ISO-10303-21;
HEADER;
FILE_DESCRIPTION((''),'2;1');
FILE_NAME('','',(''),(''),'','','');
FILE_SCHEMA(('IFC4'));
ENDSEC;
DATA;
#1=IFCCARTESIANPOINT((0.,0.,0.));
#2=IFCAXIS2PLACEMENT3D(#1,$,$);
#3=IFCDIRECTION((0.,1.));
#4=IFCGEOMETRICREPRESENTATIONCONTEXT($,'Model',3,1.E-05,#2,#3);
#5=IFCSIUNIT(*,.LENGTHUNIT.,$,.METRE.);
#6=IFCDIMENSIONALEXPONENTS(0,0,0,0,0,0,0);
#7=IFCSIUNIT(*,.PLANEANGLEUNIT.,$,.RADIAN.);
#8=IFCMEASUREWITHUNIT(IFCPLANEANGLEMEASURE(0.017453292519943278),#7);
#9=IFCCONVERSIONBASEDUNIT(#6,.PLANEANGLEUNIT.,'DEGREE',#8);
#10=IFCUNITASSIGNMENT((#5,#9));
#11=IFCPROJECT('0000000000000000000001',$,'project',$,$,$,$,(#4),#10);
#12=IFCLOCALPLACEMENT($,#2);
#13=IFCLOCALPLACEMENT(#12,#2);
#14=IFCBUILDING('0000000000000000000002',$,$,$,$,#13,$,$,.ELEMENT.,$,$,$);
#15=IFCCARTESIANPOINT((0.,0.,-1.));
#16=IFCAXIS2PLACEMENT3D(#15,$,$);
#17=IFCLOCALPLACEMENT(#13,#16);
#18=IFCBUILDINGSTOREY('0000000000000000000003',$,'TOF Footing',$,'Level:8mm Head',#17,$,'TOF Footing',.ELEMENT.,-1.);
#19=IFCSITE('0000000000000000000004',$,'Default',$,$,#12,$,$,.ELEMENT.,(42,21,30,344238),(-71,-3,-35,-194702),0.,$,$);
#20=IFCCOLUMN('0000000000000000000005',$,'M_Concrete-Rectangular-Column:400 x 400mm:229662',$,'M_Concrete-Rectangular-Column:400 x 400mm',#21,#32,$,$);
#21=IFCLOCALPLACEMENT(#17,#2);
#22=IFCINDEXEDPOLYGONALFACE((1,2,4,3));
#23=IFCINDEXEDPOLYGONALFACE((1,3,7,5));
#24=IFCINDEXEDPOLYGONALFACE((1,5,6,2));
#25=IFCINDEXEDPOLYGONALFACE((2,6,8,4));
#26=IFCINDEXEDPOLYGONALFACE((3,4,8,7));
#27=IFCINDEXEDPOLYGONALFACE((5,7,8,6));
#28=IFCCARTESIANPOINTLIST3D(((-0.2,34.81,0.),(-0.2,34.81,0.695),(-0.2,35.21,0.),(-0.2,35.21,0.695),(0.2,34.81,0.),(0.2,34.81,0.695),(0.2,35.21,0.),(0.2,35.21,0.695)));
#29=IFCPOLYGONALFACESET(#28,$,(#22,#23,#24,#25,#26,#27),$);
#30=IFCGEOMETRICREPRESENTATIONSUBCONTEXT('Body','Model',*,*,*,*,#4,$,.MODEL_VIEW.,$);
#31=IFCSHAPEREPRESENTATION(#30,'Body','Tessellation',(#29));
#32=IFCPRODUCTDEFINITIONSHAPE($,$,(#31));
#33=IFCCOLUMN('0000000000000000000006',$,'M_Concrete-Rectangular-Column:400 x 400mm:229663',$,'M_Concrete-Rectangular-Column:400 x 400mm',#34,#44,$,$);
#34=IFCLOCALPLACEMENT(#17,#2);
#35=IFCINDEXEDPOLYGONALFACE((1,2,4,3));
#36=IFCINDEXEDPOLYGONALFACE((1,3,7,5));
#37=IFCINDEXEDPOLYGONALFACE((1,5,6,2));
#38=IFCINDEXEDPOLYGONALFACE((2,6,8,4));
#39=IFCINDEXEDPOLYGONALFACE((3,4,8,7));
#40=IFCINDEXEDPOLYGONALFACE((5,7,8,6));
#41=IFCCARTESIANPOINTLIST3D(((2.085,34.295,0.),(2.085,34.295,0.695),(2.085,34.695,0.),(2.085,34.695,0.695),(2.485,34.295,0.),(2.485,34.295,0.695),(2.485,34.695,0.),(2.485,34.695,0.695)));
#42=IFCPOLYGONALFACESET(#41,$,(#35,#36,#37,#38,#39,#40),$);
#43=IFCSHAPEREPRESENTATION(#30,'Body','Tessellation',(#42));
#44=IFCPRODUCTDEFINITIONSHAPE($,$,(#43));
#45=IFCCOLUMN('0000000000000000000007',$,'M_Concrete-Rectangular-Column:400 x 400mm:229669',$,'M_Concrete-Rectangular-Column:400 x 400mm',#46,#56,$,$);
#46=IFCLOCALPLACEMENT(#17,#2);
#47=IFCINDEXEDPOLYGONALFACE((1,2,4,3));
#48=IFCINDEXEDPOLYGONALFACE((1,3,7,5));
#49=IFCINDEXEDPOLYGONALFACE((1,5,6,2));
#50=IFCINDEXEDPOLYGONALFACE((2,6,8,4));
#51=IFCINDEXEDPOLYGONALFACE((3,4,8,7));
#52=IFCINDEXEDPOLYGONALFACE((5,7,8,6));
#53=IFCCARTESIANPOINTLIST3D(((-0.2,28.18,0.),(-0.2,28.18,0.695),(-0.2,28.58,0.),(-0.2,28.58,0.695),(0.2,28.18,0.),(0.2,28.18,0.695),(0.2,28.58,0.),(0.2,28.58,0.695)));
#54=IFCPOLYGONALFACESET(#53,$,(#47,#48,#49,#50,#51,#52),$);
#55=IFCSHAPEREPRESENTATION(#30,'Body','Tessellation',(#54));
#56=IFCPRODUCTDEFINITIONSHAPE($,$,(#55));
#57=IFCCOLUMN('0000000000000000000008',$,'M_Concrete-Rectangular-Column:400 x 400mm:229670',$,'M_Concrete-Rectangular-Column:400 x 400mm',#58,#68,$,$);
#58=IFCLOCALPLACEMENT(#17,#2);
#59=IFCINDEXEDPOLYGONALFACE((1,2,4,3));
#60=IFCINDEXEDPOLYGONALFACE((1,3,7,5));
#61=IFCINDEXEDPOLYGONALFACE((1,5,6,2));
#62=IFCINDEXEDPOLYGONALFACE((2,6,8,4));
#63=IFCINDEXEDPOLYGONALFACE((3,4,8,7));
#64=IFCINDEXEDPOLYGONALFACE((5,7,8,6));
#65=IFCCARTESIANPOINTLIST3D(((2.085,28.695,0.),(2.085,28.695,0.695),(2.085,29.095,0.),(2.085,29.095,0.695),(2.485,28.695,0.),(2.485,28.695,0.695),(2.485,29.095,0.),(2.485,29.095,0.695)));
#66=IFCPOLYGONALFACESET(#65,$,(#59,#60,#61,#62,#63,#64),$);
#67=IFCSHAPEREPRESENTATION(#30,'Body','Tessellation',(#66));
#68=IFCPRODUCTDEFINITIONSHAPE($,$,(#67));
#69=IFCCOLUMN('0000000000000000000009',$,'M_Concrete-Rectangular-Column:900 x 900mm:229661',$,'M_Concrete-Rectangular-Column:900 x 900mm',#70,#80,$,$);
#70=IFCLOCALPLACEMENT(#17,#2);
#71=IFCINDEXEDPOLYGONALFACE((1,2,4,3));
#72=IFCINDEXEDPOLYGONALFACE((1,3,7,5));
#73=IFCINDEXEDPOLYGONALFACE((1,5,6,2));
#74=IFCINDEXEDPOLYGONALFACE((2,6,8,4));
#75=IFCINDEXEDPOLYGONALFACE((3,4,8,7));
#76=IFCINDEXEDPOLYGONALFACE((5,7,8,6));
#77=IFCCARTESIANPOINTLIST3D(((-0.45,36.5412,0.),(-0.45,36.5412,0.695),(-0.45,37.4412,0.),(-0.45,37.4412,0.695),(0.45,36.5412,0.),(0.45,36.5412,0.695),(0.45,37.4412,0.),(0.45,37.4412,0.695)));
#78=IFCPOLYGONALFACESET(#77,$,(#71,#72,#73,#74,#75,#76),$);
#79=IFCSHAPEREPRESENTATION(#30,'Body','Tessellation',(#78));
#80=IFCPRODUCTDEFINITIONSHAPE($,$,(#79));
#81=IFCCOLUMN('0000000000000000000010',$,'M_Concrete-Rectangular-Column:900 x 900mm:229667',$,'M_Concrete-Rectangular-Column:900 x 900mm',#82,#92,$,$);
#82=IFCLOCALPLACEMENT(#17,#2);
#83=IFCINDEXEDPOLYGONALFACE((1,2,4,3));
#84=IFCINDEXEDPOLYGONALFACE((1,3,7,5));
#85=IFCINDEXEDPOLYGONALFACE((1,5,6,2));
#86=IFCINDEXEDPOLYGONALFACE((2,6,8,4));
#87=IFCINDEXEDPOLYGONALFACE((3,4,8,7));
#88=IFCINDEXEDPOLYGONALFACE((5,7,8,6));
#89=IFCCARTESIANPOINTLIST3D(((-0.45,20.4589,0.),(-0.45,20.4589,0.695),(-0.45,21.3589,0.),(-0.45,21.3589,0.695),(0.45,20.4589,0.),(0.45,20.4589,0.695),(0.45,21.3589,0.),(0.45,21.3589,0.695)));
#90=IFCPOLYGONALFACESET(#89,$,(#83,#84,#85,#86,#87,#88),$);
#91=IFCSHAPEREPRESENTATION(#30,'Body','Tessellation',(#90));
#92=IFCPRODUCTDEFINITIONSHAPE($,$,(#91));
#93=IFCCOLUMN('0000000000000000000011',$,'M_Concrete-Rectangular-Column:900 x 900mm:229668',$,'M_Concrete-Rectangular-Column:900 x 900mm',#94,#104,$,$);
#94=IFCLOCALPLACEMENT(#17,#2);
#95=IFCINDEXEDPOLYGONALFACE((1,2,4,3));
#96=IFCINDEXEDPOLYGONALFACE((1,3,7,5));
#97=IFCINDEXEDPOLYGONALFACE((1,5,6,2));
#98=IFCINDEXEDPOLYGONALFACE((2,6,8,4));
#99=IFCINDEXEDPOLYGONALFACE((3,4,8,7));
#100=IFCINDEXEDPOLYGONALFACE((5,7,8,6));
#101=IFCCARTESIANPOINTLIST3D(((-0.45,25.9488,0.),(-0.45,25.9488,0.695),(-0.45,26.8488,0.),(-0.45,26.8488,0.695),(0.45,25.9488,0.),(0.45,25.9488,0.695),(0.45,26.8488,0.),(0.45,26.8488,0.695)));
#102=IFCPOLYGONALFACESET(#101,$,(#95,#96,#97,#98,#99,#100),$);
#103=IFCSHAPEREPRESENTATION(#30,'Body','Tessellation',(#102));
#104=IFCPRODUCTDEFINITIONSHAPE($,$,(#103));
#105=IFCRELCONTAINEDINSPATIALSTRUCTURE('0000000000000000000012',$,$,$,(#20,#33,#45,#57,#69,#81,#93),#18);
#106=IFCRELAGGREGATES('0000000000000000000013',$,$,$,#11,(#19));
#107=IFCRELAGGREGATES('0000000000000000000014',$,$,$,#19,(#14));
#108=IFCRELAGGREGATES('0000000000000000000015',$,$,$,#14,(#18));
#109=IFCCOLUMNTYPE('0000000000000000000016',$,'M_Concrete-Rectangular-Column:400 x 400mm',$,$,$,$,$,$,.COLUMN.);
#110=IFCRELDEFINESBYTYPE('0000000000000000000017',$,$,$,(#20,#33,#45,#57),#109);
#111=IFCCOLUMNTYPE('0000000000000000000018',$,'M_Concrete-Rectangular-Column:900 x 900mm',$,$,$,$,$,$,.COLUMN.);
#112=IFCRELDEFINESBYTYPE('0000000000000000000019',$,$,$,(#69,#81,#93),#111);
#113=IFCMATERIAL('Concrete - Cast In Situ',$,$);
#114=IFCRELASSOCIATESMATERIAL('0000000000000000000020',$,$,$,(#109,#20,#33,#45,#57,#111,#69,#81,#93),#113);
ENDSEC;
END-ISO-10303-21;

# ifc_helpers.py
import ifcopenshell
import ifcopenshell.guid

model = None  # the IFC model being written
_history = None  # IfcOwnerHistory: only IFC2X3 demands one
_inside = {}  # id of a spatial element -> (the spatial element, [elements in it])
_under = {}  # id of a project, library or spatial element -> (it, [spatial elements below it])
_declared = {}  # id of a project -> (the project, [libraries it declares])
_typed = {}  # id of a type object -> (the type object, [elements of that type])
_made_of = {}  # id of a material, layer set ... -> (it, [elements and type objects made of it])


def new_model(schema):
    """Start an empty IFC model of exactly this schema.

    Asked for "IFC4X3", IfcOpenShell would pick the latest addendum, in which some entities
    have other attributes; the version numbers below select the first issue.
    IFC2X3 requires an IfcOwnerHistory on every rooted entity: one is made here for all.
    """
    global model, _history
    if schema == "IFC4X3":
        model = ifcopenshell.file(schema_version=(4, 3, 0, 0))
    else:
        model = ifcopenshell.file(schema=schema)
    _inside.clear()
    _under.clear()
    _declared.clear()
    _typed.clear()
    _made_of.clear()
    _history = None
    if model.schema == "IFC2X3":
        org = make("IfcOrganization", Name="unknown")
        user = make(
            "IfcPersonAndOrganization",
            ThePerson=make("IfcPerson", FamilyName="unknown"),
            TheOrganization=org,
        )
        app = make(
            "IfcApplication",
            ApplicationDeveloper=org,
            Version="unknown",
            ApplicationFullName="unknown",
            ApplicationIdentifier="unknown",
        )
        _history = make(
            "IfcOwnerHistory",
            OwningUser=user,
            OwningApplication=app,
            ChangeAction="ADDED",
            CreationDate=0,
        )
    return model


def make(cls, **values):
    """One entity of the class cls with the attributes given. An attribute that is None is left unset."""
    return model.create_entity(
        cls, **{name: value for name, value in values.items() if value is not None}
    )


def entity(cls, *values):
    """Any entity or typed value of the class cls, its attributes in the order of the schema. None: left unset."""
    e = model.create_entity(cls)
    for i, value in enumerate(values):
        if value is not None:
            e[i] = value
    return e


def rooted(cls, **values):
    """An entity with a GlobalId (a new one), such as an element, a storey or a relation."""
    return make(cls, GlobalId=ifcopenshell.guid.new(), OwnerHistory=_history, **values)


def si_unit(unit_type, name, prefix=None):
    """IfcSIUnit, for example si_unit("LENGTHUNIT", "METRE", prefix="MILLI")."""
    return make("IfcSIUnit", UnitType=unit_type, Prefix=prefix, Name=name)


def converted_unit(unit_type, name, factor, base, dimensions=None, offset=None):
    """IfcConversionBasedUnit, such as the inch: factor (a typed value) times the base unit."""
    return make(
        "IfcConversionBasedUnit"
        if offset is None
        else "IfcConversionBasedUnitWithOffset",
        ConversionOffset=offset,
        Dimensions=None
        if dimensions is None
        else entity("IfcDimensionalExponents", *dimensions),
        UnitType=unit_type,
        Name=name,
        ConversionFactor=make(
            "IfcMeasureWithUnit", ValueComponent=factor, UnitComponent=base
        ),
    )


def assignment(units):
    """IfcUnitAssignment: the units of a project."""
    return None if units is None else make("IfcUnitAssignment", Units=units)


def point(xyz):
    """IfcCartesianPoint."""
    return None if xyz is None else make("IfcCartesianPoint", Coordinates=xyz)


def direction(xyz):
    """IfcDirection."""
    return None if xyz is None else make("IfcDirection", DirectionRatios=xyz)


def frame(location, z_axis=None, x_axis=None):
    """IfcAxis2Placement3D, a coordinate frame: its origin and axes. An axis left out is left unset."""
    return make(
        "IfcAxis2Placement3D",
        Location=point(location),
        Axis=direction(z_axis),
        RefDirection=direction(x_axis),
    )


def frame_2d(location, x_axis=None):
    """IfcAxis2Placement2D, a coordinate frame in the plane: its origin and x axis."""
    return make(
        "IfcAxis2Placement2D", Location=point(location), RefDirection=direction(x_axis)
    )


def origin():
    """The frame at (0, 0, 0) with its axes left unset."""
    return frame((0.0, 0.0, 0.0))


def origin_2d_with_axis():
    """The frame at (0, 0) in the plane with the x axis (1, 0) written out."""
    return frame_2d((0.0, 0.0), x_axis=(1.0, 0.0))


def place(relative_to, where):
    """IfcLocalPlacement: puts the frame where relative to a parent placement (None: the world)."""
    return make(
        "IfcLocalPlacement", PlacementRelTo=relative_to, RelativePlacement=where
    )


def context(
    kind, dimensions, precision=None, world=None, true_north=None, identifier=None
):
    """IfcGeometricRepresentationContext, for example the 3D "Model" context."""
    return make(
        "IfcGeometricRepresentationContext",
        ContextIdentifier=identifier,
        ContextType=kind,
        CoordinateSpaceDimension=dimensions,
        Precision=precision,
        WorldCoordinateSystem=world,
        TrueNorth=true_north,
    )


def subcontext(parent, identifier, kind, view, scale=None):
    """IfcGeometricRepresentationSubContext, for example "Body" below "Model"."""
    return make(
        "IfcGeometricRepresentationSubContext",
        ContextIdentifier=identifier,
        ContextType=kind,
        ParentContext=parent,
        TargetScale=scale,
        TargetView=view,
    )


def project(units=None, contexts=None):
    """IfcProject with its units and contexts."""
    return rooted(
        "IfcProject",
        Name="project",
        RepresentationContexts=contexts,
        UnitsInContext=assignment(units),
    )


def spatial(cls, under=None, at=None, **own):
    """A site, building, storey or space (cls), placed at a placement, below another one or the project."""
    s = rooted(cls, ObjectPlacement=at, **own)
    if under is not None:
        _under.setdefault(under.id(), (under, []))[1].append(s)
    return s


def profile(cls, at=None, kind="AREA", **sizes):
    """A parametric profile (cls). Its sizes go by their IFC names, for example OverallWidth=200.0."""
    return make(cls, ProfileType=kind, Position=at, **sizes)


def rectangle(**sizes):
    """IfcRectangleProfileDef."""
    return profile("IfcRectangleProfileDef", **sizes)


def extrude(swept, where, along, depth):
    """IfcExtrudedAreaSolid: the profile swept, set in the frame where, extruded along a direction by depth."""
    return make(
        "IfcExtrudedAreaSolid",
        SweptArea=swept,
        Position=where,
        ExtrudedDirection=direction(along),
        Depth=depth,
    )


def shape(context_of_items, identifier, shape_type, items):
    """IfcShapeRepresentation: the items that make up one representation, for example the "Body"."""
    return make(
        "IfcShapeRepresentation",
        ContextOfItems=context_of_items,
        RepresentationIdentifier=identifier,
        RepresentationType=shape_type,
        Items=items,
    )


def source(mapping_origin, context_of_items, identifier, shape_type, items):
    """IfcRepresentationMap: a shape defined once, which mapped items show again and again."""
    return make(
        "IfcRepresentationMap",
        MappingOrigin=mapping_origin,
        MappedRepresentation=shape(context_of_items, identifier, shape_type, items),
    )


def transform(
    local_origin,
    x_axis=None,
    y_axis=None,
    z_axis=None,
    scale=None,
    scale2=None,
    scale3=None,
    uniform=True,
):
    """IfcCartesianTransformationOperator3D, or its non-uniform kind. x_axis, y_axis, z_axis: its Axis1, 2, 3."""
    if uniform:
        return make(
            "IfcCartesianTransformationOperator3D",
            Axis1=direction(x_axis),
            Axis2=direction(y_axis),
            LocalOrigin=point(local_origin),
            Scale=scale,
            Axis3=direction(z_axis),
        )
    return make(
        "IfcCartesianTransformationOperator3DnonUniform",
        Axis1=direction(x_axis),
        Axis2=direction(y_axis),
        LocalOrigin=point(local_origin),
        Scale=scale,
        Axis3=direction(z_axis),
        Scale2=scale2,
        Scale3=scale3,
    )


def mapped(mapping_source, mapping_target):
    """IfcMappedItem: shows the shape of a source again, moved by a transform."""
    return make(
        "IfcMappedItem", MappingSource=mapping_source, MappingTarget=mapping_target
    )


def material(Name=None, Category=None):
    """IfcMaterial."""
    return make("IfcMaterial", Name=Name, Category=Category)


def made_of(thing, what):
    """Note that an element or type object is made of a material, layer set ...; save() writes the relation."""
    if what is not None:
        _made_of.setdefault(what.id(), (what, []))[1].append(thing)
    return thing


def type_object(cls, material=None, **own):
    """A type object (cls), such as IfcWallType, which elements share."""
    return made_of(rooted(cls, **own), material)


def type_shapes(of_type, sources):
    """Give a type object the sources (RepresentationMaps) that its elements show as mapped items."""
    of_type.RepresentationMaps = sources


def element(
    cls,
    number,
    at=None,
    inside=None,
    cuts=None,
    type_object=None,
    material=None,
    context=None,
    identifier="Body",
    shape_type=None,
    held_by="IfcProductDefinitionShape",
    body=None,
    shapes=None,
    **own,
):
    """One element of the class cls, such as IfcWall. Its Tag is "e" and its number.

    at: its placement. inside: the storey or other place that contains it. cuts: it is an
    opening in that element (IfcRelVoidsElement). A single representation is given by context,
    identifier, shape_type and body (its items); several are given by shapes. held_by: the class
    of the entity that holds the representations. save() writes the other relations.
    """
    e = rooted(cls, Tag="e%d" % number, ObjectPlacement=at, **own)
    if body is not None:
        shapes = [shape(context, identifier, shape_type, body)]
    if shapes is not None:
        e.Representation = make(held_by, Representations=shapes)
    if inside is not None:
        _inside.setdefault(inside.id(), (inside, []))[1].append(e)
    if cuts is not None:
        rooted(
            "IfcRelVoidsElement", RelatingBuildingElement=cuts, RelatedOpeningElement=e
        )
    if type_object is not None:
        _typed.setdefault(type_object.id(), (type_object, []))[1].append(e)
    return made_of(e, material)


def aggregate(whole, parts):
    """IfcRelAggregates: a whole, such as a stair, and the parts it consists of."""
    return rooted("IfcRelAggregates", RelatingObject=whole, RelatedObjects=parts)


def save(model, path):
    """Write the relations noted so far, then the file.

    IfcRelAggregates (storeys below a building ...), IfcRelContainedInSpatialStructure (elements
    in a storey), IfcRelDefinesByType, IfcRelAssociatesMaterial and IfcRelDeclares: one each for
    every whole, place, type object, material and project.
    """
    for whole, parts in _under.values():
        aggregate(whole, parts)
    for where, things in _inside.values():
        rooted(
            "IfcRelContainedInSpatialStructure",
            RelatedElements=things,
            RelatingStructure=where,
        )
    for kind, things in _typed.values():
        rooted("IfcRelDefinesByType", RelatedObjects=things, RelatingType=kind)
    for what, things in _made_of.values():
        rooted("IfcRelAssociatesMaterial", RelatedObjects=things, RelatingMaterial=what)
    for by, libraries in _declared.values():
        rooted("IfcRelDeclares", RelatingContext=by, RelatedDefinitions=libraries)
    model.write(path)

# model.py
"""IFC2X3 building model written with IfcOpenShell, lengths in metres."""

from ifc_helpers import new_model, entity, si_unit, converted_unit, direction, frame, origin, origin_2d_with_axis, place, context, subcontext, project, spatial, rectangle, extrude, source, transform, mapped, material, type_object, type_shapes, element, save


model = new_model("IFC2X3")

# Units and contexts
model_context = context("Model", 3, precision=1e-05, world=origin(), true_north=direction((0.0, 1.0)))
body_context = subcontext(model_context, "Body", "Model", "MODEL_VIEW")
ifc_project = project(units=[si_unit("LENGTHUNIT", "METRE"), converted_unit("PLANEANGLEUNIT", "DEGREE", entity("IfcPlaneAngleMeasure", 0.017453292519943278), si_unit("PLANEANGLEUNIT", "RADIAN"), dimensions=[0, 0, 0, 0, 0, 0, 0])], contexts=[model_context])

# Site, building, storey
site_placement = place(None, origin())
site = spatial("IfcSite", under=ifc_project, at=site_placement, Name="Default", CompositionType="ELEMENT", RefLatitude=(42, 21, 30, 344238), RefLongitude=(-71, -3, -35, -194702), RefElevation=0.0)
building_placement = place(site_placement, origin())
building = spatial("IfcBuilding", under=site, at=building_placement, CompositionType="ELEMENT")
storey_placement = place(building_placement, frame((0.0, 0.0, -1.0)))
storey = spatial("IfcBuildingStorey", under=building, at=storey_placement, Name="TOF Footing", ObjectType="Level:8mm Head", LongName="TOF Footing", CompositionType="ELEMENT", Elevation=-1.0)

# Columns
ifc_material_1 = material(Name="Concrete - Cast In Situ")
column_type_1 = type_object("IfcColumnType", Name="M_Concrete-Rectangular-Column:400 x 400mm", PredefinedType="COLUMN", material=ifc_material_1)
shared_shape_1 = source(origin(), body_context, "Body", "SweptSolid", [
    extrude(rectangle(XDim=0.4, YDim=0.4, at=origin_2d_with_axis()), frame((0.0, 0.0, -1.0), z_axis=(0.0, 0.0, 1.0), x_axis=(-1.0, 0.0, 0.0)), (0.0, 0.0, 1.0), 0.695),
])
type_shapes(column_type_1, [shared_shape_1])
for number, where, z_axis, x_axis, name in (
    (1, (0.0, 35.01, 1.0), (0.0, 0.0, 1.0), (-1.0, 0.0, 0.0), "M_Concrete-Rectangular-Column:400 x 400mm:229662"),
    (2, (2.285, 34.495, 1.0), (0.0, 0.0, 1.0), (-1.0, 0.0, 0.0), "M_Concrete-Rectangular-Column:400 x 400mm:229663"),
):
    element("IfcColumn", number, at=place(storey_placement, frame(where, z_axis=z_axis, x_axis=x_axis)), inside=storey, type_object=column_type_1, material=ifc_material_1, Name=name, ObjectType="M_Concrete-Rectangular-Column:400 x 400mm", context=body_context, shape_type="MappedRepresentation", body=[
        mapped(shared_shape_1, transform((0.0, 0.0, 0.0), scale=1.0)),
    ])
for number, where, name in (
    (3, (0.0, 28.38, 1.0), "M_Concrete-Rectangular-Column:400 x 400mm:229669"),
    (4, (2.285, 28.895, 1.0), "M_Concrete-Rectangular-Column:400 x 400mm:229670"),
):
    element("IfcColumn", number, at=place(storey_placement, frame(where)), inside=storey, type_object=column_type_1, material=ifc_material_1, Name=name, ObjectType="M_Concrete-Rectangular-Column:400 x 400mm", context=body_context, shape_type="MappedRepresentation", body=[
        mapped(shared_shape_1, transform((0.0, 0.0, 0.0), scale=1.0)),
    ])
column_type_2 = type_object("IfcColumnType", Name="M_Concrete-Rectangular-Column:900 x 900mm", PredefinedType="COLUMN", material=ifc_material_1)
shared_shape_2 = source(origin(), body_context, "Body", "SweptSolid", [
    extrude(rectangle(XDim=0.9, YDim=0.9, at=origin_2d_with_axis()), frame((0.0, 0.0, -1.0), z_axis=(0.0, 0.0, 1.0), x_axis=(-1.0, 0.0, 0.0)), (0.0, 0.0, 1.0), 0.695),
])
type_shapes(column_type_2, [shared_shape_2])
column_placement = place(storey_placement, frame((0.0, 36.9912, 1.0), z_axis=(0.0, 0.0, 1.0), x_axis=(-1.0, 0.0, 0.0)))
element("IfcColumn", 5, at=column_placement, inside=storey, type_object=column_type_2, material=ifc_material_1, Name="M_Concrete-Rectangular-Column:900 x 900mm:229661", ObjectType="M_Concrete-Rectangular-Column:900 x 900mm", context=body_context, shape_type="MappedRepresentation", body=[
    mapped(shared_shape_2, transform((0.0, 0.0, 0.0), scale=1.0)),
])
for number, where, name in (
    (6, (0.0, 20.9089, 1.0), "M_Concrete-Rectangular-Column:900 x 900mm:229667"),
    (7, (0.0, 26.3988, 1.0), "M_Concrete-Rectangular-Column:900 x 900mm:229668"),
):
    element("IfcColumn", number, at=place(storey_placement, frame(where)), inside=storey, type_object=column_type_2, material=ifc_material_1, Name=name, ObjectType="M_Concrete-Rectangular-Column:900 x 900mm", context=body_context, shape_type="MappedRepresentation", body=[
        mapped(shared_shape_2, transform((0.0, 0.0, 0.0), scale=1.0)),
    ])

save(model, "model.ifc")
